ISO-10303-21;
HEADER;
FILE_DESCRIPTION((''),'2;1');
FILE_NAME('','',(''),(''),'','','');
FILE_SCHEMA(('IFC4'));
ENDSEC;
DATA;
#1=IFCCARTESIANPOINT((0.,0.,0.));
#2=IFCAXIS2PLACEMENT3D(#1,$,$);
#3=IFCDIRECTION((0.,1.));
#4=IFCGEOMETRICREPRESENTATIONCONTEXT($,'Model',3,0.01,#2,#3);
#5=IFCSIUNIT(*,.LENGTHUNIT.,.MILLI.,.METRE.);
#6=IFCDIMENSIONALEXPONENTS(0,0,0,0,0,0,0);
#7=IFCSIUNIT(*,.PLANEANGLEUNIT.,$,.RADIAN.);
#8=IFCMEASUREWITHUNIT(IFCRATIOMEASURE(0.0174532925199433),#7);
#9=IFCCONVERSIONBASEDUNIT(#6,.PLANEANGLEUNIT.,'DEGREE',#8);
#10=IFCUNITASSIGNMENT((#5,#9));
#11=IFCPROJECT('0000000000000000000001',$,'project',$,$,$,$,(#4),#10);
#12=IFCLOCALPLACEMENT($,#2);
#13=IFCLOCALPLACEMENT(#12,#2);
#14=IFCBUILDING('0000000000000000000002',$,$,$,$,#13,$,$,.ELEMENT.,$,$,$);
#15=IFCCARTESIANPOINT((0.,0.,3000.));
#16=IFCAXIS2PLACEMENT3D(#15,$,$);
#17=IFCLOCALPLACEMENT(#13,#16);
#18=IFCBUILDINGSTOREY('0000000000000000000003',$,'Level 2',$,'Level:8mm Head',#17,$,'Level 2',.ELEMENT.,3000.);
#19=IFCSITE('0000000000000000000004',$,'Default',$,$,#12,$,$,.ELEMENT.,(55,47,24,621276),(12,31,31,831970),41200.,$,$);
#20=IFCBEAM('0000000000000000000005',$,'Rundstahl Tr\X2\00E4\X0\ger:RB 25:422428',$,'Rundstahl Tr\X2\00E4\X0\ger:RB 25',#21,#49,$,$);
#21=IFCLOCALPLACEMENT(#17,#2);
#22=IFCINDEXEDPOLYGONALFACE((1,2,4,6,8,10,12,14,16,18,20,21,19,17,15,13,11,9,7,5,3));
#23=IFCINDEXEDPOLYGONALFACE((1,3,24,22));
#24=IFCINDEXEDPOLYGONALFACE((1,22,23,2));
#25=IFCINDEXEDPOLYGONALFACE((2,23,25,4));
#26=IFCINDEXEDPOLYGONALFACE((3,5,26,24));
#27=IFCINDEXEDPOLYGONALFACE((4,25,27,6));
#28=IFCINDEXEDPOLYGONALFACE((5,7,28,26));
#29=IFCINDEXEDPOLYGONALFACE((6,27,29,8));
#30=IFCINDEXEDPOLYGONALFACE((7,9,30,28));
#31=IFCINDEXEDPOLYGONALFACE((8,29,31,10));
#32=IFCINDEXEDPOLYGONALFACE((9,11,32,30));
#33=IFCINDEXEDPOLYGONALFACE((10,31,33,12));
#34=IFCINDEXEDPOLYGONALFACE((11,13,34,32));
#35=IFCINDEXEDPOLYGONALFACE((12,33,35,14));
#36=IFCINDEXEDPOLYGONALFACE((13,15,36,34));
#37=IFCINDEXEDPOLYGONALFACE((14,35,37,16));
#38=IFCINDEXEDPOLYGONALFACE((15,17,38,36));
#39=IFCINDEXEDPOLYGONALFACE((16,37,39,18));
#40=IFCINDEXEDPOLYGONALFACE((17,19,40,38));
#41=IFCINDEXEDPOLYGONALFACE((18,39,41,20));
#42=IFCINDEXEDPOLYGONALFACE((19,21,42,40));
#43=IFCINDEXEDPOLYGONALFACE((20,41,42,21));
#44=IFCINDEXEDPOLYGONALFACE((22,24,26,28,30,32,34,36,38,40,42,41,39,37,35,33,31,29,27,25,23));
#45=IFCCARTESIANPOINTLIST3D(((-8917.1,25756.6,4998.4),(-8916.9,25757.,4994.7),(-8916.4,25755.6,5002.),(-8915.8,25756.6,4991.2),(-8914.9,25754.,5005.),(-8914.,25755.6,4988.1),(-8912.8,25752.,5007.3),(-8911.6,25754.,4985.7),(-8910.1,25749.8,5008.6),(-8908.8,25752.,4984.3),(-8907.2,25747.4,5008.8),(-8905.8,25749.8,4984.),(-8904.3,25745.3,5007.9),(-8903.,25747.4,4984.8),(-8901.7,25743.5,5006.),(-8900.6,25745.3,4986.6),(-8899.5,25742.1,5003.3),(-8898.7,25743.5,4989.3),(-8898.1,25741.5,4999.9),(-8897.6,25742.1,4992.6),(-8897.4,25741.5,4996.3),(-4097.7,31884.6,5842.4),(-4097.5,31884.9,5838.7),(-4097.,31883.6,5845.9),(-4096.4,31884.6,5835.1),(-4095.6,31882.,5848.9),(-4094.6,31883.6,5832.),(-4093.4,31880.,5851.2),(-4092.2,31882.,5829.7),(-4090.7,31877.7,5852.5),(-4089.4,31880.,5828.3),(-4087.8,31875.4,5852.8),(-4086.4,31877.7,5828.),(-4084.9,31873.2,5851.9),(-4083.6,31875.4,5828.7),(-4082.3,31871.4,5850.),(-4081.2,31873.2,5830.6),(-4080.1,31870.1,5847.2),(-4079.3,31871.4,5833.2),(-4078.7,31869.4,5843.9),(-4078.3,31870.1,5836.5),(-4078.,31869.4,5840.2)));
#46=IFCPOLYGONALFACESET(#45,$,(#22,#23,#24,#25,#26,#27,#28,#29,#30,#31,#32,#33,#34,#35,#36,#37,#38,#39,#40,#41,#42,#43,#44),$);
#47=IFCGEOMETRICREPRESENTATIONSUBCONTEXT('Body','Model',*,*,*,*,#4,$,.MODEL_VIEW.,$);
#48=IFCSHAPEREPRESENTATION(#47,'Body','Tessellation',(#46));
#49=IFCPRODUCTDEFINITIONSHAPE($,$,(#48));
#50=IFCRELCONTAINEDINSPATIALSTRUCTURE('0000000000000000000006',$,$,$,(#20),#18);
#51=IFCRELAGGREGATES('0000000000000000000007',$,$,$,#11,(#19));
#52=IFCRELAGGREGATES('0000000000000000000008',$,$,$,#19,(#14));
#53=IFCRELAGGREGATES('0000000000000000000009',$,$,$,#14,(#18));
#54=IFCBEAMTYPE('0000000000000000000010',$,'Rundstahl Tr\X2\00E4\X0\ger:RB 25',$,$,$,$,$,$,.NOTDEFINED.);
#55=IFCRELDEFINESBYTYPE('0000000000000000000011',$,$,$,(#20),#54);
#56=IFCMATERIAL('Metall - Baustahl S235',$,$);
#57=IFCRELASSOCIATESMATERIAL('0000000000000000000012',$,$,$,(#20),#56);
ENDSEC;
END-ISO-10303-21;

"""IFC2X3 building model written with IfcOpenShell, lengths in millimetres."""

from ifc_helpers import new_model, entity, si_unit, converted_unit, direction, frame, frame_2d, origin, place, context, subcontext, project, spatial, circle, extrude, material, type_object, element, save


model = new_model("IFC2X3")

# Units and contexts
model_context = context("Model", 3, precision=0.01, world=origin(), true_north=direction((0.0, 1.0)))
body_context = subcontext(model_context, "Body", "Model", "MODEL_VIEW")
ifc_project = project(units=[si_unit("LENGTHUNIT", "METRE", prefix="MILLI"), converted_unit("PLANEANGLEUNIT", "DEGREE", entity("IfcRatioMeasure", 0.0174532925199433), si_unit("PLANEANGLEUNIT", "RADIAN"), dimensions=[0, 0, 0, 0, 0, 0, 0])], contexts=[model_context])

# Site, building, storey
site_placement = place(None, origin())
site = spatial("IfcSite", under=ifc_project, at=site_placement, Name="Default", CompositionType="ELEMENT", RefLatitude=(55, 47, 24, 621276), RefLongitude=(12, 31, 31, 831970), RefElevation=41200.0)
building_placement = place(site_placement, origin())
building = spatial("IfcBuilding", under=site, at=building_placement, CompositionType="ELEMENT")
storey_placement = place(building_placement, frame((0.0, 0.0, 3000.0)))
storey = spatial("IfcBuildingStorey", under=building, at=storey_placement, Name="Level 2", ObjectType="Level:8mm Head", LongName="Level 2", CompositionType="ELEMENT", Elevation=3000.0)

# Beam
ifc_material_1 = material(Name="Metall - Baustahl S235")
beam_type_1 = type_object("IfcBeamType", Name="Rundstahl Träger:RB 25", PredefinedType="NOTDEFINED")
beam_1_placement = place(storey_placement, frame((-4090.0, 31877.2, 5852.7), z_axis=(-0.066532, -0.084597, 0.994192), x_axis=(-0.614592, -0.781469, -0.107625)))
element("IfcBeam", 1, at=beam_1_placement, inside=storey, type_object=beam_type_1, material=ifc_material_1, Name="Rundstahl Träger:RB 25:422428", ObjectType="Rundstahl Träger:RB 25", context=body_context, shape_type="SweptSolid", body=[
    extrude(circle(Radius=12.5, at=frame_2d((0.0, 0.0), x_axis=(1.0, 0.0))), frame((0.0, 1.7, -12.4), z_axis=(1.0, 0.0, 0.0), x_axis=(0.0, -0.990766, -0.135584)), (0.0, 0.0, 1.0), 7841.6),
])

save(model, "model.ifc")
